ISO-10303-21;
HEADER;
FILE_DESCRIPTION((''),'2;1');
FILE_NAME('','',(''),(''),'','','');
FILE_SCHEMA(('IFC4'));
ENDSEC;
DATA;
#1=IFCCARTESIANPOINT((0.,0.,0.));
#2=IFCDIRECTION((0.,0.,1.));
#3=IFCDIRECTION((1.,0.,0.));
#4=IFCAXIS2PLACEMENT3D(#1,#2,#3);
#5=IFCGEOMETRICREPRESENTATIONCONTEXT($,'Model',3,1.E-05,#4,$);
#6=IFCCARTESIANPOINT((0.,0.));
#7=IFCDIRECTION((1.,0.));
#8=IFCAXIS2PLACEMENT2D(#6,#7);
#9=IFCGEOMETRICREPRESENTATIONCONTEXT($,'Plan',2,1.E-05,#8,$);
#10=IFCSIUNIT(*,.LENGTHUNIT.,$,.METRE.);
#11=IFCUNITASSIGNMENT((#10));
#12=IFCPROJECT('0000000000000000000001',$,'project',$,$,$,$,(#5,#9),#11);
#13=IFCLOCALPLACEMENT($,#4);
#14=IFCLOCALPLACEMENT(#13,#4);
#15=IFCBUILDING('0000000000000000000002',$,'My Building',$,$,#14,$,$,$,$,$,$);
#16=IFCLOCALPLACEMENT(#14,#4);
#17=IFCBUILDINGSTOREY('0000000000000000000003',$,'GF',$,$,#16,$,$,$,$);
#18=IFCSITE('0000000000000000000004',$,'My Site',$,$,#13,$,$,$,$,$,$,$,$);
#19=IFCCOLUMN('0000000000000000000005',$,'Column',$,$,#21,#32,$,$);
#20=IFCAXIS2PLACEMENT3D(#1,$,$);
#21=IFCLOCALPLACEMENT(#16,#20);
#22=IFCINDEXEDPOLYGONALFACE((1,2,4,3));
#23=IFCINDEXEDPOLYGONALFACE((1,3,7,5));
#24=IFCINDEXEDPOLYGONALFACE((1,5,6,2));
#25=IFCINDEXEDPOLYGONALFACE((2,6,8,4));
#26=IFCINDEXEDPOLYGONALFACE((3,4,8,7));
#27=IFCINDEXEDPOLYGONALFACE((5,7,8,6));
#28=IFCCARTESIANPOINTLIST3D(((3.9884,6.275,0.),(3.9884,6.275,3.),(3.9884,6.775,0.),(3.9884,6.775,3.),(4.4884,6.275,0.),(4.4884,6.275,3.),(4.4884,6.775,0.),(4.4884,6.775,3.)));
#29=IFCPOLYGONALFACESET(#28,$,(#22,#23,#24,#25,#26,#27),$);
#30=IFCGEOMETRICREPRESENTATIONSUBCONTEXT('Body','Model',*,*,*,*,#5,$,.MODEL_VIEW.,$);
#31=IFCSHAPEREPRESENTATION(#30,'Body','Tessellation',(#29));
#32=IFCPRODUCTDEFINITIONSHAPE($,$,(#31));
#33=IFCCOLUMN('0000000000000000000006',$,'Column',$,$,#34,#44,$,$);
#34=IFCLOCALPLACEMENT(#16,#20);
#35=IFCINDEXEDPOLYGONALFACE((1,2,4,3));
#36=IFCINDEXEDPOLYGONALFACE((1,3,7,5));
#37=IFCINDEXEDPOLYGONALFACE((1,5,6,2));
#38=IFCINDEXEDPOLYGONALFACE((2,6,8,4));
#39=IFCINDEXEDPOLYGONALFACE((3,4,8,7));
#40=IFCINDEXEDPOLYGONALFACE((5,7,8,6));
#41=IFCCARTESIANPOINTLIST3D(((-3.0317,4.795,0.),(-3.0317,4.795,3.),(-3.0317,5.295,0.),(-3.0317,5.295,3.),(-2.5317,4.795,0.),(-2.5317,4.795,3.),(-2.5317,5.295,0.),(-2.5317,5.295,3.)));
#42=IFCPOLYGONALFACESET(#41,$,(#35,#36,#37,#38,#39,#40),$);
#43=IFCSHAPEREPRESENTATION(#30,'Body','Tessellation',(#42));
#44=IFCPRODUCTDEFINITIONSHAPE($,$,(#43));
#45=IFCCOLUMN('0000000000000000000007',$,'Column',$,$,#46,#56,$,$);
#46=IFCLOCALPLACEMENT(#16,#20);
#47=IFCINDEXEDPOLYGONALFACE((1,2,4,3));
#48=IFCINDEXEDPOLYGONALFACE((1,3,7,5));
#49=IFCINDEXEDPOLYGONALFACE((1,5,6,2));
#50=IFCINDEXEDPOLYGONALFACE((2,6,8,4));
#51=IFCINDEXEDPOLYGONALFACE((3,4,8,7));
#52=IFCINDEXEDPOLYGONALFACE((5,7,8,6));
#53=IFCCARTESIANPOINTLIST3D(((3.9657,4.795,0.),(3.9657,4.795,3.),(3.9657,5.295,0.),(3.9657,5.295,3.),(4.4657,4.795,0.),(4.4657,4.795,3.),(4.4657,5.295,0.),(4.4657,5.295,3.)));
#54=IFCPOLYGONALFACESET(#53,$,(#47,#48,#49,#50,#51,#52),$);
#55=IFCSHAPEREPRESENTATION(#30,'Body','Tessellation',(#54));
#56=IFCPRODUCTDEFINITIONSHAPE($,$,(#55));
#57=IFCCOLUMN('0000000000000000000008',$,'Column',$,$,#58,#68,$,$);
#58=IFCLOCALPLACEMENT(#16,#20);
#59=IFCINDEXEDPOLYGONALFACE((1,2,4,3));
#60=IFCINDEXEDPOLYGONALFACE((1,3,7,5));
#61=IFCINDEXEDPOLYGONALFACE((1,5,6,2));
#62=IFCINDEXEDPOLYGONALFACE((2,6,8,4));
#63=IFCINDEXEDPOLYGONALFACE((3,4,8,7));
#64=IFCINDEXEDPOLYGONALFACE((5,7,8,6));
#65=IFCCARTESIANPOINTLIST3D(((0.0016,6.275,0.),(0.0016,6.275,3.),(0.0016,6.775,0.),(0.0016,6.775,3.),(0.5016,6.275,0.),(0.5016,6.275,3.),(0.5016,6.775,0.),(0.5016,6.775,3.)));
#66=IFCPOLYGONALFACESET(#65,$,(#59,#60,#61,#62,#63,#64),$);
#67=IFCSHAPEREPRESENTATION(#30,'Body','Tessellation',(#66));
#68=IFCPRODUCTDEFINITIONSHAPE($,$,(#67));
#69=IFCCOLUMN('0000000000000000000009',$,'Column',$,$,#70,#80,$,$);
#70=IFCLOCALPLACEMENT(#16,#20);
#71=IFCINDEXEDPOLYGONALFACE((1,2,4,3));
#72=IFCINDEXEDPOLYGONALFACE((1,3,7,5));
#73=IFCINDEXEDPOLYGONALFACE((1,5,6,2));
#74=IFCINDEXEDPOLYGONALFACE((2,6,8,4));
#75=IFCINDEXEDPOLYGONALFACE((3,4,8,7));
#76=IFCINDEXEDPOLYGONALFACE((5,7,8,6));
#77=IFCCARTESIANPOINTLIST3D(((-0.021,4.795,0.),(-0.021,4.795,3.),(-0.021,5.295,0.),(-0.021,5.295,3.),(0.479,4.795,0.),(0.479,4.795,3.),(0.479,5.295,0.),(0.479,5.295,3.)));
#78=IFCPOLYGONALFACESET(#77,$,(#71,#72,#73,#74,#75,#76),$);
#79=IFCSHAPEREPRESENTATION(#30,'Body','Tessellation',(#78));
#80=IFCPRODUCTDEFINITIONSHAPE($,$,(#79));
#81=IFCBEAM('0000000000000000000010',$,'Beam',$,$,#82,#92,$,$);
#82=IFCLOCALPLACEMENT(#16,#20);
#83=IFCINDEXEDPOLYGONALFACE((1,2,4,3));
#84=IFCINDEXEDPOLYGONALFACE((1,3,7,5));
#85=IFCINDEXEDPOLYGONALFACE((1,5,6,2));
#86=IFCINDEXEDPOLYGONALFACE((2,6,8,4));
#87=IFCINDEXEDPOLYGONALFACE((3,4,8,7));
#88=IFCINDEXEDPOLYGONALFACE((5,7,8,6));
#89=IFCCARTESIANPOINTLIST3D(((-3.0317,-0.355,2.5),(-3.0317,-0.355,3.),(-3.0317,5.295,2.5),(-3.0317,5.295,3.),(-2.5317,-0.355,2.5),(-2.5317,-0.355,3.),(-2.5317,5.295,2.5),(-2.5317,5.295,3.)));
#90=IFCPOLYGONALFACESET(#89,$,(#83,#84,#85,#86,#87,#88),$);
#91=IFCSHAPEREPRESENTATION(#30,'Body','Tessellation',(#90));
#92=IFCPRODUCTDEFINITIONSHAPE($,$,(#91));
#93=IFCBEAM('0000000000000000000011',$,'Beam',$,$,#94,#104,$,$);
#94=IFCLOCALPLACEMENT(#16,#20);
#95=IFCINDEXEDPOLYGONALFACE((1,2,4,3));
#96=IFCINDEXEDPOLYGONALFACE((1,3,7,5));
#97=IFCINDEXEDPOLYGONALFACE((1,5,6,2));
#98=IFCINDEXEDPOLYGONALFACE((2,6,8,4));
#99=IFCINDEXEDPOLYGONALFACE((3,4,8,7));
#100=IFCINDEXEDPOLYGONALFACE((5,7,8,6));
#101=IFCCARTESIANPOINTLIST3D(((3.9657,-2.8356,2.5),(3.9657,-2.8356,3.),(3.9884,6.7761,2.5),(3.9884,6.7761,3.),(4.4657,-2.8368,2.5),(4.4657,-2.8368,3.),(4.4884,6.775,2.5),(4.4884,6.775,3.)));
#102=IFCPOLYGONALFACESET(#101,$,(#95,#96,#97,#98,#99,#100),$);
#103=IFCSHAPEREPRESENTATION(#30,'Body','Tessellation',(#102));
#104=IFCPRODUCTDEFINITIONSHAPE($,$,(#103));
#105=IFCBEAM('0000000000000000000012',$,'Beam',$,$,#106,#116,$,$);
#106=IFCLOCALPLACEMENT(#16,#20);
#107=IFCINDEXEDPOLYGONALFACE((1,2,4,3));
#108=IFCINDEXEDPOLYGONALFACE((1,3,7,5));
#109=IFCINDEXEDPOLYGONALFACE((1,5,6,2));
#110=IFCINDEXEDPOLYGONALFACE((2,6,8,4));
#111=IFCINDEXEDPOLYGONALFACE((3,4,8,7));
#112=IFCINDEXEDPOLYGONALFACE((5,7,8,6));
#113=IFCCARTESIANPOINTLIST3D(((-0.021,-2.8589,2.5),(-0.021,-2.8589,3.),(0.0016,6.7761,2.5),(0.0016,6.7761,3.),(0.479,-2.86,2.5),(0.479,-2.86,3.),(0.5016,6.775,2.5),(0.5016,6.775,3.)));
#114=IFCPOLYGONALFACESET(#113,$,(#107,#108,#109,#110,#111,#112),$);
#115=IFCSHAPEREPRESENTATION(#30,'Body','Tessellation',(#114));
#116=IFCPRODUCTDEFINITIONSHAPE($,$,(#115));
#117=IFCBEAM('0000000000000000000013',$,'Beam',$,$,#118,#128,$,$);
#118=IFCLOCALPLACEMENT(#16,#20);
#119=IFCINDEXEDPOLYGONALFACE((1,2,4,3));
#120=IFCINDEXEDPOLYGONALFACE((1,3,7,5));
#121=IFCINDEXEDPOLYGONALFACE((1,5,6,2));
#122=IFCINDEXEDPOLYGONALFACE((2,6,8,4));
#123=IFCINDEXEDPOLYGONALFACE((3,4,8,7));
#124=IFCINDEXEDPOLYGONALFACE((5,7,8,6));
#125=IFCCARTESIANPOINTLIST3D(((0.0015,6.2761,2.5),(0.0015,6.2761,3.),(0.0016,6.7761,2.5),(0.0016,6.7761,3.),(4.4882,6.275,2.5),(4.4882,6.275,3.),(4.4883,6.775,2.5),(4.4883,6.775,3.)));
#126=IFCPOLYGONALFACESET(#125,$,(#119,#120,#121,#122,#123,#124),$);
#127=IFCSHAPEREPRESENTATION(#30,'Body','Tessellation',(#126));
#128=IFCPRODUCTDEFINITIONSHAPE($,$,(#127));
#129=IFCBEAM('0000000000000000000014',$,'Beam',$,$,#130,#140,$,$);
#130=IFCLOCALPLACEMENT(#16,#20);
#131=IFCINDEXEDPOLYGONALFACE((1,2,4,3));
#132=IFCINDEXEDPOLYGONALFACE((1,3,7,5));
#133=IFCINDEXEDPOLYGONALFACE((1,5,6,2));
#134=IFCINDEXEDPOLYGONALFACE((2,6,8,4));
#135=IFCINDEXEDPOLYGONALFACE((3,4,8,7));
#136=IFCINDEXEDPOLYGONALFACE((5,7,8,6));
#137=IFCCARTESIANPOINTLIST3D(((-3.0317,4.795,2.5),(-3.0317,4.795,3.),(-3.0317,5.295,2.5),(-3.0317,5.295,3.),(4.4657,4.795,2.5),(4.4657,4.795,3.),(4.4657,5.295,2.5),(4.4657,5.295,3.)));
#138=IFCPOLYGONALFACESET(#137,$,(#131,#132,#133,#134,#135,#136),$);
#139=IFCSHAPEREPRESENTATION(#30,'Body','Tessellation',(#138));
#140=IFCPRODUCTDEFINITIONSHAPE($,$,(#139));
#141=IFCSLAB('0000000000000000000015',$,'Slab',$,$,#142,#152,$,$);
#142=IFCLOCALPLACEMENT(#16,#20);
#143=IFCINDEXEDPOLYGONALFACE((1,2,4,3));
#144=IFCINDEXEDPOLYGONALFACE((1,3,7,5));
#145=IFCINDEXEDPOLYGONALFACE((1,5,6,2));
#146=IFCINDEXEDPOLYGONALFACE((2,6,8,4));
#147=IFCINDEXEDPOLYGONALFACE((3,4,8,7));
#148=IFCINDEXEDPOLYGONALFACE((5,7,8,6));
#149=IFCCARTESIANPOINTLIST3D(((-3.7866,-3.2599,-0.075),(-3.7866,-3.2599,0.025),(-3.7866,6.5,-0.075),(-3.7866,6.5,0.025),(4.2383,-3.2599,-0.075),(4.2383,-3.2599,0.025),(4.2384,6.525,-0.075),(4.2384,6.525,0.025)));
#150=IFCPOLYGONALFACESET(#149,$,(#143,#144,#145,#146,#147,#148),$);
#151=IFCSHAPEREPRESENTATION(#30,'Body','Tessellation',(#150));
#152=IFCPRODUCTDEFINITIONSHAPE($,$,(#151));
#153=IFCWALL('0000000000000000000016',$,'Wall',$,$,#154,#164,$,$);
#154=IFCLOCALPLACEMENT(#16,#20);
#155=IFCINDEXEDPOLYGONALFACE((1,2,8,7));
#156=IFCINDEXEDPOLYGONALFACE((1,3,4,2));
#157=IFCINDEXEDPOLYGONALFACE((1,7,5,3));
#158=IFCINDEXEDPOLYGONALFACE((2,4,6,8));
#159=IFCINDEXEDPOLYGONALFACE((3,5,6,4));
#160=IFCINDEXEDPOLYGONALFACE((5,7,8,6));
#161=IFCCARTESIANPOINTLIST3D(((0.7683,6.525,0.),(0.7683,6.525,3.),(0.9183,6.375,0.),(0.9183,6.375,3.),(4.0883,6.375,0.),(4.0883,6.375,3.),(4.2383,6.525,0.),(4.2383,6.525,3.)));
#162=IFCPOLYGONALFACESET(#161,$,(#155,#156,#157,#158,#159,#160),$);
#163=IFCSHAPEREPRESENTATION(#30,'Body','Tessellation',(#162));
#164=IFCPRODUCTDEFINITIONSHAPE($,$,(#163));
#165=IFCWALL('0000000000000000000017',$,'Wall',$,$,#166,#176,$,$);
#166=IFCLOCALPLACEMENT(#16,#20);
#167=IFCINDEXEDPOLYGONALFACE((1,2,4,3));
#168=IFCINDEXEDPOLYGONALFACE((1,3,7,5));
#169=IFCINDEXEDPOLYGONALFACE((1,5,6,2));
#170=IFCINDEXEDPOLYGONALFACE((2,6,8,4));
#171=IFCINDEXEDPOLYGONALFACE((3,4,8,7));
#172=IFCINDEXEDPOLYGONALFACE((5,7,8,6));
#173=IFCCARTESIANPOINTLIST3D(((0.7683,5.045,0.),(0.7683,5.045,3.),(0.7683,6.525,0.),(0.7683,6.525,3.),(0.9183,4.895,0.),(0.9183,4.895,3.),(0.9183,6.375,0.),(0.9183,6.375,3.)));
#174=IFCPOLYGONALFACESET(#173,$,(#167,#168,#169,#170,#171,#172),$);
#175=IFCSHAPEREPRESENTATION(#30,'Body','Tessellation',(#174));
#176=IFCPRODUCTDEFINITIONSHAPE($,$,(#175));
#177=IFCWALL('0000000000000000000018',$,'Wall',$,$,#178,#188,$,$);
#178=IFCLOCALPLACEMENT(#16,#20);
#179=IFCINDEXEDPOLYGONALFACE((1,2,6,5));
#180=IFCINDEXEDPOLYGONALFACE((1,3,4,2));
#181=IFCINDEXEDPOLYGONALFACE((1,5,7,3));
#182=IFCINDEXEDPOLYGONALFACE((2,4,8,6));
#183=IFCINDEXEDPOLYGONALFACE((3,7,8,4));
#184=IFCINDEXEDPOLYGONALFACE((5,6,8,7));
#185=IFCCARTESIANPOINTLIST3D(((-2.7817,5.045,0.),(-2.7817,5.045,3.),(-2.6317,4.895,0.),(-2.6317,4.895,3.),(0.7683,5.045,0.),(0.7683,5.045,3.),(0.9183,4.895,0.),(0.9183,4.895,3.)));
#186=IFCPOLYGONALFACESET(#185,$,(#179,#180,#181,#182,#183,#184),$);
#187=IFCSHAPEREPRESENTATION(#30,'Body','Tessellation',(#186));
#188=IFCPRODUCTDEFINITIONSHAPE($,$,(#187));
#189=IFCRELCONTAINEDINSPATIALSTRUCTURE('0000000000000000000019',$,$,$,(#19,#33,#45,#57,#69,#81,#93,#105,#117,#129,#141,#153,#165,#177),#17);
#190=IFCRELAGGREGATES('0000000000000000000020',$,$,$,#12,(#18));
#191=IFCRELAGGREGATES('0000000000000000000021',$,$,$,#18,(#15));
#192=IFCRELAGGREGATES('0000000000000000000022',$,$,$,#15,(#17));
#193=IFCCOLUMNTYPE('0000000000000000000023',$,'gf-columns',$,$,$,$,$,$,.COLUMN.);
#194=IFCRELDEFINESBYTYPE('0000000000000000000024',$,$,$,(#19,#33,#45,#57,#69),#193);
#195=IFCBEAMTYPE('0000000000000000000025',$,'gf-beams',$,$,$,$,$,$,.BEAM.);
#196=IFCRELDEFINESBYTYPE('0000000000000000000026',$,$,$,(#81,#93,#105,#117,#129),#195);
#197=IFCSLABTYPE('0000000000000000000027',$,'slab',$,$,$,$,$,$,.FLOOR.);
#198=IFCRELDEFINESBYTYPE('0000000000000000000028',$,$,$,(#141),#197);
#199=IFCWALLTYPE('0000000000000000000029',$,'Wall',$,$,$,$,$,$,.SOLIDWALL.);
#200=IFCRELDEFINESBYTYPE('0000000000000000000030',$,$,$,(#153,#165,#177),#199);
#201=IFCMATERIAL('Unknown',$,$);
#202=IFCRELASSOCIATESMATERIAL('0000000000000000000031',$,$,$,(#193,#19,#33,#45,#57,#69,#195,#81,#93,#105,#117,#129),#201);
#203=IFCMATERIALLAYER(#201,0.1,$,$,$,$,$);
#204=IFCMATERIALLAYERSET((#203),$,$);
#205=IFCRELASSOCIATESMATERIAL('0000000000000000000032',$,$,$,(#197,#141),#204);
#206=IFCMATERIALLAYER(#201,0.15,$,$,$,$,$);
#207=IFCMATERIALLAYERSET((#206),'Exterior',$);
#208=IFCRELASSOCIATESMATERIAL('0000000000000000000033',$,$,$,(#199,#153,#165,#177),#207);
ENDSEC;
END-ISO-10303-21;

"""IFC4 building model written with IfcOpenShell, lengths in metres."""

from ifc_helpers import new_model, si_unit, frame, origin_with_axes, origin_2d_with_axis, place, context, subcontext, project, spatial, line, indexed_curve, rectangle, outline, extrude, material, layer, layer_set, layer_usage, material_profile, profile_set, profile_usage, type_object, element, save


model = new_model("IFC4")

# Units and contexts
model_context = context("Model", 3, precision=1e-05, world=origin_with_axes())
plan_context = context("Plan", 2, precision=1e-05, world=origin_2d_with_axis())
body_context_1 = subcontext(model_context, "Body", "Model", "MODEL_VIEW")
ifc_project = project(units=[si_unit("LENGTHUNIT", "METRE")], contexts=[model_context, plan_context])

# Site, building, storey
site_placement = place(None, origin_with_axes())
site = spatial("IfcSite", under=ifc_project, at=site_placement, Name="My Site")
building_placement = place(site_placement, origin_with_axes())
building = spatial("IfcBuilding", under=site, at=building_placement, Name="My Building")
storey_placement = place(building_placement, origin_with_axes())
storey = spatial("IfcBuildingStorey", under=building, at=storey_placement, Name="GF")

# Columns
ifc_material = material(Name="Unknown")
ifc_material_profile_1 = material_profile(ifc_material, rectangle(XDim=0.5, YDim=0.5))
ifc_profile_set_1 = profile_set([ifc_material_profile_1])
ifc_profile_usage_1 = profile_usage(ifc_profile_set_1, cardinal=5)
column_type = type_object("IfcColumnType", Name="gf-columns", PredefinedType="COLUMN", material=ifc_profile_set_1)
column_1_placement = place(storey_placement, frame((4.2384, 6.525, 0.0), z_axis=(0.0, 0.0, 1.0), x_axis=(1.0, 0.0, 0.0)))
element("IfcColumn", 1, at=column_1_placement, inside=storey, type_object=column_type, material=ifc_profile_usage_1, Name="Column", context=body_context_1, shape_type="SweptSolid", body=[
    extrude(rectangle(XDim=0.5, YDim=0.5), origin_with_axes(), (0.0, 0.0, 1.0), 3.0),
])
ifc_profile_usage_2 = profile_usage(ifc_profile_set_1, cardinal=5)
column_2_placement = place(storey_placement, frame((-2.7817, 5.045, 0.0), z_axis=(0.0, 0.0, 1.0), x_axis=(1.0, 0.0, 0.0)))
element("IfcColumn", 2, at=column_2_placement, inside=storey, type_object=column_type, material=ifc_profile_usage_2, Name="Column", context=body_context_1, shape_type="SweptSolid", body=[
    extrude(rectangle(XDim=0.5, YDim=0.5), origin_with_axes(), (0.0, 0.0, 1.0), 3.0),
])
ifc_profile_usage_3 = profile_usage(ifc_profile_set_1, cardinal=5)
column_3_placement = place(storey_placement, frame((4.2157, 5.045, 0.0), z_axis=(0.0, 0.0, 1.0), x_axis=(1.0, 0.0, 0.0)))
element("IfcColumn", 3, at=column_3_placement, inside=storey, type_object=column_type, material=ifc_profile_usage_3, Name="Column", context=body_context_1, shape_type="SweptSolid", body=[
    extrude(rectangle(XDim=0.5, YDim=0.5), origin_with_axes(), (0.0, 0.0, 1.0), 3.0),
])
ifc_profile_usage_4 = profile_usage(ifc_profile_set_1, cardinal=5)
column_4_placement = place(storey_placement, frame((0.2516, 6.525, 0.0), z_axis=(0.0, 0.0, 1.0), x_axis=(1.0, 0.0, 0.0)))
element("IfcColumn", 4, at=column_4_placement, inside=storey, type_object=column_type, material=ifc_profile_usage_4, Name="Column", context=body_context_1, shape_type="SweptSolid", body=[
    extrude(rectangle(XDim=0.5, YDim=0.5), origin_with_axes(), (0.0, 0.0, 1.0), 3.0),
])
ifc_profile_usage_5 = profile_usage(ifc_profile_set_1, cardinal=5)
column_5_placement = place(storey_placement, frame((0.229, 5.045, 0.0), z_axis=(0.0, 0.0, 1.0), x_axis=(1.0, 0.0, 0.0)))
element("IfcColumn", 5, at=column_5_placement, inside=storey, type_object=column_type, material=ifc_profile_usage_5, Name="Column", context=body_context_1, shape_type="SweptSolid", body=[
    extrude(rectangle(XDim=0.5, YDim=0.5), origin_with_axes(), (0.0, 0.0, 1.0), 3.0),
])

# Beams
ifc_material_profile_2 = material_profile(ifc_material, rectangle(XDim=0.5, YDim=0.5))
ifc_profile_set_2 = profile_set([ifc_material_profile_2])
ifc_profile_usage_6 = profile_usage(ifc_profile_set_2, cardinal=7)
beam_type = type_object("IfcBeamType", Name="gf-beams", PredefinedType="BEAM", material=ifc_profile_set_2)
beam_1_placement = place(storey_placement, frame((-2.5317, 5.295, 3.0), z_axis=(0.0, -1.0, 0.0), x_axis=(1.0, 0.0, 0.0)))
element("IfcBeam", 6, at=beam_1_placement, inside=storey, type_object=beam_type, material=ifc_profile_usage_6, Name="Beam", context=body_context_1, shape_type="SweptSolid", body=[
    extrude(rectangle(XDim=0.5, YDim=0.5), frame((-0.25, -0.25, 0.0), z_axis=(0.0, 0.0, 1.0), x_axis=(1.0, 0.0, 0.0)), (0.0, 0.0, 1.0), 5.65),
])
ifc_profile_usage_7 = profile_usage(ifc_profile_set_2, cardinal=7)
beam_2_placement = place(storey_placement, frame((4.4884, 6.775, 3.0), z_axis=(-0.002353, -0.999997, 0.0), x_axis=(0.999997, -0.002353, 0.0)))
element("IfcBeam", 7, at=beam_2_placement, inside=storey, type_object=beam_type, material=ifc_profile_usage_7, Name="Beam", context=body_context_1, shape_type="SweptSolid", body=[
    extrude(rectangle(XDim=0.5, YDim=0.5), frame((-0.25, -0.25, 0.0), z_axis=(0.0, 0.0, 1.0), x_axis=(1.0, 0.0, 0.0)), (0.0, 0.0, 1.0), 9.6118),
])
ifc_profile_usage_8 = profile_usage(ifc_profile_set_2, cardinal=7)
beam_3_placement = place(storey_placement, frame((0.5016, 6.775, 3.0), z_axis=(-0.002347, -0.999997, 0.0), x_axis=(0.999997, -0.002347, 0.0)))
element("IfcBeam", 8, at=beam_3_placement, inside=storey, type_object=beam_type, material=ifc_profile_usage_8, Name="Beam", context=body_context_1, shape_type="SweptSolid", body=[
    extrude(rectangle(XDim=0.5, YDim=0.5), frame((-0.25, -0.25, 0.0), z_axis=(0.0, 0.0, 1.0), x_axis=(1.0, 0.0, 0.0)), (0.0, 0.0, 1.0), 9.635),
])
ifc_profile_usage_9 = profile_usage(ifc_profile_set_2, cardinal=7)
beam_4_placement = place(storey_placement, frame((0.0016, 6.7761, 3.0), z_axis=(1.0, -0.000261, -0.000001), x_axis=(0.000261, 1.0, 0.0)))
element("IfcBeam", 9, at=beam_4_placement, inside=storey, type_object=beam_type, material=ifc_profile_usage_9, Name="Beam", context=body_context_1, shape_type="SweptSolid", body=[
    extrude(rectangle(XDim=0.5, YDim=0.5), frame((-0.25, -0.25, 0.0), z_axis=(0.0, 0.0, 1.0), x_axis=(1.0, 0.0, 0.0)), (0.0, 0.0, 1.0), 4.4867),
])
ifc_profile_usage_10 = profile_usage(ifc_profile_set_2, cardinal=7)
beam_5_placement = place(storey_placement, frame((-3.0317, 5.295, 3.0), z_axis=(1.0, 0.0, 0.0), x_axis=(0.0, 1.0, 0.0)))
element("IfcBeam", 10, at=beam_5_placement, inside=storey, type_object=beam_type, material=ifc_profile_usage_10, Name="Beam", context=body_context_1, shape_type="SweptSolid", body=[
    extrude(rectangle(XDim=0.5, YDim=0.5), frame((-0.25, -0.25, 0.0), z_axis=(0.0, 0.0, 1.0), x_axis=(1.0, 0.0, 0.0)), (0.0, 0.0, 1.0), 7.4974),
])

# Slab
ifc_layer_1 = layer(ifc_material, 0.1)
ifc_layer_set_1 = layer_set([ifc_layer_1])
ifc_layer_usage_1 = layer_usage(ifc_layer_set_1, "AXIS3", "POSITIVE", -0.1)
slab_type = type_object("IfcSlabType", Name="slab", PredefinedType="FLOOR", material=ifc_layer_set_1)
slab_placement = place(storey_placement, frame((4.2384, 6.525, 0.025), z_axis=(0.0, 0.0, 1.0), x_axis=(1.0, 0.0, 0.0)))
element("IfcSlab", 11, at=slab_placement, inside=storey, type_object=slab_type, material=ifc_layer_usage_1, Name="Slab", context=body_context_1, shape_type="SweptSolid", body=[
    extrude(outline(indexed_curve([(0.0, 0.0), (0.0, -9.7849), (-8.025, -9.7849), (-8.025, -0.025), (0.0, 0.0)])), frame((0.0, 0.0, -0.1), z_axis=(0.0, 0.0, 1.0), x_axis=(1.0, 0.0, 0.0)), (0.0, 0.0, 1.0), 0.1),
])

# Walls
ifc_layer_2 = layer(ifc_material, 0.15)
ifc_layer_set_2 = layer_set([ifc_layer_2], Name="Exterior")
ifc_layer_usage_2 = layer_usage(ifc_layer_set_2, "AXIS2", "POSITIVE", 0.0)
wall_type_1 = type_object("IfcWallType", Name="Wall", PredefinedType="SOLIDWALL", material=ifc_layer_set_2)
wall_1_placement = place(storey_placement, frame((4.2383, 6.525, 0.0), z_axis=(0.0, 0.0, 1.0), x_axis=(-1.0, 0.0, 0.0)))
element("IfcWall", 12, at=wall_1_placement, inside=storey, type_object=wall_type_1, material=ifc_layer_usage_2, Name="Wall", context=body_context_1, shape_type="SweptSolid", body=[
    extrude(outline(indexed_curve([(0.0, 0.0), (0.15, 0.15), (3.32, 0.15), (3.47, 0.0)], segments=[line(1, 2, 3, 4, 1)])), origin_with_axes(), (0.0, 0.0, 1.0), 3.0),
])
ifc_layer_usage_3 = layer_usage(ifc_layer_set_2, "AXIS2", "POSITIVE", 0.0)
wall_2_placement = place(storey_placement, frame((0.7683, 6.525, 0.0), z_axis=(0.0, 0.0, 1.0), x_axis=(0.0, -1.0, 0.0)))
element("IfcWall", 13, at=wall_2_placement, inside=storey, type_object=wall_type_1, material=ifc_layer_usage_3, Name="Wall", context=body_context_1, shape_type="SweptSolid", body=[
    extrude(outline(indexed_curve([(0.0, 0.0), (0.15, 0.15), (1.63, 0.15), (1.48, 0.0)], segments=[line(1, 2, 3, 4, 1)])), origin_with_axes(), (0.0, 0.0, 1.0), 3.0),
])
ifc_layer_usage_4 = layer_usage(ifc_layer_set_2, "AXIS2", "POSITIVE", 0.0)
wall_3_placement = place(storey_placement, frame((0.7683, 5.045, 0.0), z_axis=(0.0, 0.0, 1.0), x_axis=(-1.0, 0.0, 0.0)))
element("IfcWall", 14, at=wall_3_placement, inside=storey, type_object=wall_type_1, material=ifc_layer_usage_4, Name="Wall", context=body_context_1, shape_type="SweptSolid", body=[
    extrude(outline(indexed_curve([(0.0, 0.0), (-0.15, 0.15), (3.4, 0.15), (3.55, 0.0)], segments=[line(1, 2, 3, 4, 1)])), origin_with_axes(), (0.0, 0.0, 1.0), 3.0),
])

save(model, "model.ifc")
